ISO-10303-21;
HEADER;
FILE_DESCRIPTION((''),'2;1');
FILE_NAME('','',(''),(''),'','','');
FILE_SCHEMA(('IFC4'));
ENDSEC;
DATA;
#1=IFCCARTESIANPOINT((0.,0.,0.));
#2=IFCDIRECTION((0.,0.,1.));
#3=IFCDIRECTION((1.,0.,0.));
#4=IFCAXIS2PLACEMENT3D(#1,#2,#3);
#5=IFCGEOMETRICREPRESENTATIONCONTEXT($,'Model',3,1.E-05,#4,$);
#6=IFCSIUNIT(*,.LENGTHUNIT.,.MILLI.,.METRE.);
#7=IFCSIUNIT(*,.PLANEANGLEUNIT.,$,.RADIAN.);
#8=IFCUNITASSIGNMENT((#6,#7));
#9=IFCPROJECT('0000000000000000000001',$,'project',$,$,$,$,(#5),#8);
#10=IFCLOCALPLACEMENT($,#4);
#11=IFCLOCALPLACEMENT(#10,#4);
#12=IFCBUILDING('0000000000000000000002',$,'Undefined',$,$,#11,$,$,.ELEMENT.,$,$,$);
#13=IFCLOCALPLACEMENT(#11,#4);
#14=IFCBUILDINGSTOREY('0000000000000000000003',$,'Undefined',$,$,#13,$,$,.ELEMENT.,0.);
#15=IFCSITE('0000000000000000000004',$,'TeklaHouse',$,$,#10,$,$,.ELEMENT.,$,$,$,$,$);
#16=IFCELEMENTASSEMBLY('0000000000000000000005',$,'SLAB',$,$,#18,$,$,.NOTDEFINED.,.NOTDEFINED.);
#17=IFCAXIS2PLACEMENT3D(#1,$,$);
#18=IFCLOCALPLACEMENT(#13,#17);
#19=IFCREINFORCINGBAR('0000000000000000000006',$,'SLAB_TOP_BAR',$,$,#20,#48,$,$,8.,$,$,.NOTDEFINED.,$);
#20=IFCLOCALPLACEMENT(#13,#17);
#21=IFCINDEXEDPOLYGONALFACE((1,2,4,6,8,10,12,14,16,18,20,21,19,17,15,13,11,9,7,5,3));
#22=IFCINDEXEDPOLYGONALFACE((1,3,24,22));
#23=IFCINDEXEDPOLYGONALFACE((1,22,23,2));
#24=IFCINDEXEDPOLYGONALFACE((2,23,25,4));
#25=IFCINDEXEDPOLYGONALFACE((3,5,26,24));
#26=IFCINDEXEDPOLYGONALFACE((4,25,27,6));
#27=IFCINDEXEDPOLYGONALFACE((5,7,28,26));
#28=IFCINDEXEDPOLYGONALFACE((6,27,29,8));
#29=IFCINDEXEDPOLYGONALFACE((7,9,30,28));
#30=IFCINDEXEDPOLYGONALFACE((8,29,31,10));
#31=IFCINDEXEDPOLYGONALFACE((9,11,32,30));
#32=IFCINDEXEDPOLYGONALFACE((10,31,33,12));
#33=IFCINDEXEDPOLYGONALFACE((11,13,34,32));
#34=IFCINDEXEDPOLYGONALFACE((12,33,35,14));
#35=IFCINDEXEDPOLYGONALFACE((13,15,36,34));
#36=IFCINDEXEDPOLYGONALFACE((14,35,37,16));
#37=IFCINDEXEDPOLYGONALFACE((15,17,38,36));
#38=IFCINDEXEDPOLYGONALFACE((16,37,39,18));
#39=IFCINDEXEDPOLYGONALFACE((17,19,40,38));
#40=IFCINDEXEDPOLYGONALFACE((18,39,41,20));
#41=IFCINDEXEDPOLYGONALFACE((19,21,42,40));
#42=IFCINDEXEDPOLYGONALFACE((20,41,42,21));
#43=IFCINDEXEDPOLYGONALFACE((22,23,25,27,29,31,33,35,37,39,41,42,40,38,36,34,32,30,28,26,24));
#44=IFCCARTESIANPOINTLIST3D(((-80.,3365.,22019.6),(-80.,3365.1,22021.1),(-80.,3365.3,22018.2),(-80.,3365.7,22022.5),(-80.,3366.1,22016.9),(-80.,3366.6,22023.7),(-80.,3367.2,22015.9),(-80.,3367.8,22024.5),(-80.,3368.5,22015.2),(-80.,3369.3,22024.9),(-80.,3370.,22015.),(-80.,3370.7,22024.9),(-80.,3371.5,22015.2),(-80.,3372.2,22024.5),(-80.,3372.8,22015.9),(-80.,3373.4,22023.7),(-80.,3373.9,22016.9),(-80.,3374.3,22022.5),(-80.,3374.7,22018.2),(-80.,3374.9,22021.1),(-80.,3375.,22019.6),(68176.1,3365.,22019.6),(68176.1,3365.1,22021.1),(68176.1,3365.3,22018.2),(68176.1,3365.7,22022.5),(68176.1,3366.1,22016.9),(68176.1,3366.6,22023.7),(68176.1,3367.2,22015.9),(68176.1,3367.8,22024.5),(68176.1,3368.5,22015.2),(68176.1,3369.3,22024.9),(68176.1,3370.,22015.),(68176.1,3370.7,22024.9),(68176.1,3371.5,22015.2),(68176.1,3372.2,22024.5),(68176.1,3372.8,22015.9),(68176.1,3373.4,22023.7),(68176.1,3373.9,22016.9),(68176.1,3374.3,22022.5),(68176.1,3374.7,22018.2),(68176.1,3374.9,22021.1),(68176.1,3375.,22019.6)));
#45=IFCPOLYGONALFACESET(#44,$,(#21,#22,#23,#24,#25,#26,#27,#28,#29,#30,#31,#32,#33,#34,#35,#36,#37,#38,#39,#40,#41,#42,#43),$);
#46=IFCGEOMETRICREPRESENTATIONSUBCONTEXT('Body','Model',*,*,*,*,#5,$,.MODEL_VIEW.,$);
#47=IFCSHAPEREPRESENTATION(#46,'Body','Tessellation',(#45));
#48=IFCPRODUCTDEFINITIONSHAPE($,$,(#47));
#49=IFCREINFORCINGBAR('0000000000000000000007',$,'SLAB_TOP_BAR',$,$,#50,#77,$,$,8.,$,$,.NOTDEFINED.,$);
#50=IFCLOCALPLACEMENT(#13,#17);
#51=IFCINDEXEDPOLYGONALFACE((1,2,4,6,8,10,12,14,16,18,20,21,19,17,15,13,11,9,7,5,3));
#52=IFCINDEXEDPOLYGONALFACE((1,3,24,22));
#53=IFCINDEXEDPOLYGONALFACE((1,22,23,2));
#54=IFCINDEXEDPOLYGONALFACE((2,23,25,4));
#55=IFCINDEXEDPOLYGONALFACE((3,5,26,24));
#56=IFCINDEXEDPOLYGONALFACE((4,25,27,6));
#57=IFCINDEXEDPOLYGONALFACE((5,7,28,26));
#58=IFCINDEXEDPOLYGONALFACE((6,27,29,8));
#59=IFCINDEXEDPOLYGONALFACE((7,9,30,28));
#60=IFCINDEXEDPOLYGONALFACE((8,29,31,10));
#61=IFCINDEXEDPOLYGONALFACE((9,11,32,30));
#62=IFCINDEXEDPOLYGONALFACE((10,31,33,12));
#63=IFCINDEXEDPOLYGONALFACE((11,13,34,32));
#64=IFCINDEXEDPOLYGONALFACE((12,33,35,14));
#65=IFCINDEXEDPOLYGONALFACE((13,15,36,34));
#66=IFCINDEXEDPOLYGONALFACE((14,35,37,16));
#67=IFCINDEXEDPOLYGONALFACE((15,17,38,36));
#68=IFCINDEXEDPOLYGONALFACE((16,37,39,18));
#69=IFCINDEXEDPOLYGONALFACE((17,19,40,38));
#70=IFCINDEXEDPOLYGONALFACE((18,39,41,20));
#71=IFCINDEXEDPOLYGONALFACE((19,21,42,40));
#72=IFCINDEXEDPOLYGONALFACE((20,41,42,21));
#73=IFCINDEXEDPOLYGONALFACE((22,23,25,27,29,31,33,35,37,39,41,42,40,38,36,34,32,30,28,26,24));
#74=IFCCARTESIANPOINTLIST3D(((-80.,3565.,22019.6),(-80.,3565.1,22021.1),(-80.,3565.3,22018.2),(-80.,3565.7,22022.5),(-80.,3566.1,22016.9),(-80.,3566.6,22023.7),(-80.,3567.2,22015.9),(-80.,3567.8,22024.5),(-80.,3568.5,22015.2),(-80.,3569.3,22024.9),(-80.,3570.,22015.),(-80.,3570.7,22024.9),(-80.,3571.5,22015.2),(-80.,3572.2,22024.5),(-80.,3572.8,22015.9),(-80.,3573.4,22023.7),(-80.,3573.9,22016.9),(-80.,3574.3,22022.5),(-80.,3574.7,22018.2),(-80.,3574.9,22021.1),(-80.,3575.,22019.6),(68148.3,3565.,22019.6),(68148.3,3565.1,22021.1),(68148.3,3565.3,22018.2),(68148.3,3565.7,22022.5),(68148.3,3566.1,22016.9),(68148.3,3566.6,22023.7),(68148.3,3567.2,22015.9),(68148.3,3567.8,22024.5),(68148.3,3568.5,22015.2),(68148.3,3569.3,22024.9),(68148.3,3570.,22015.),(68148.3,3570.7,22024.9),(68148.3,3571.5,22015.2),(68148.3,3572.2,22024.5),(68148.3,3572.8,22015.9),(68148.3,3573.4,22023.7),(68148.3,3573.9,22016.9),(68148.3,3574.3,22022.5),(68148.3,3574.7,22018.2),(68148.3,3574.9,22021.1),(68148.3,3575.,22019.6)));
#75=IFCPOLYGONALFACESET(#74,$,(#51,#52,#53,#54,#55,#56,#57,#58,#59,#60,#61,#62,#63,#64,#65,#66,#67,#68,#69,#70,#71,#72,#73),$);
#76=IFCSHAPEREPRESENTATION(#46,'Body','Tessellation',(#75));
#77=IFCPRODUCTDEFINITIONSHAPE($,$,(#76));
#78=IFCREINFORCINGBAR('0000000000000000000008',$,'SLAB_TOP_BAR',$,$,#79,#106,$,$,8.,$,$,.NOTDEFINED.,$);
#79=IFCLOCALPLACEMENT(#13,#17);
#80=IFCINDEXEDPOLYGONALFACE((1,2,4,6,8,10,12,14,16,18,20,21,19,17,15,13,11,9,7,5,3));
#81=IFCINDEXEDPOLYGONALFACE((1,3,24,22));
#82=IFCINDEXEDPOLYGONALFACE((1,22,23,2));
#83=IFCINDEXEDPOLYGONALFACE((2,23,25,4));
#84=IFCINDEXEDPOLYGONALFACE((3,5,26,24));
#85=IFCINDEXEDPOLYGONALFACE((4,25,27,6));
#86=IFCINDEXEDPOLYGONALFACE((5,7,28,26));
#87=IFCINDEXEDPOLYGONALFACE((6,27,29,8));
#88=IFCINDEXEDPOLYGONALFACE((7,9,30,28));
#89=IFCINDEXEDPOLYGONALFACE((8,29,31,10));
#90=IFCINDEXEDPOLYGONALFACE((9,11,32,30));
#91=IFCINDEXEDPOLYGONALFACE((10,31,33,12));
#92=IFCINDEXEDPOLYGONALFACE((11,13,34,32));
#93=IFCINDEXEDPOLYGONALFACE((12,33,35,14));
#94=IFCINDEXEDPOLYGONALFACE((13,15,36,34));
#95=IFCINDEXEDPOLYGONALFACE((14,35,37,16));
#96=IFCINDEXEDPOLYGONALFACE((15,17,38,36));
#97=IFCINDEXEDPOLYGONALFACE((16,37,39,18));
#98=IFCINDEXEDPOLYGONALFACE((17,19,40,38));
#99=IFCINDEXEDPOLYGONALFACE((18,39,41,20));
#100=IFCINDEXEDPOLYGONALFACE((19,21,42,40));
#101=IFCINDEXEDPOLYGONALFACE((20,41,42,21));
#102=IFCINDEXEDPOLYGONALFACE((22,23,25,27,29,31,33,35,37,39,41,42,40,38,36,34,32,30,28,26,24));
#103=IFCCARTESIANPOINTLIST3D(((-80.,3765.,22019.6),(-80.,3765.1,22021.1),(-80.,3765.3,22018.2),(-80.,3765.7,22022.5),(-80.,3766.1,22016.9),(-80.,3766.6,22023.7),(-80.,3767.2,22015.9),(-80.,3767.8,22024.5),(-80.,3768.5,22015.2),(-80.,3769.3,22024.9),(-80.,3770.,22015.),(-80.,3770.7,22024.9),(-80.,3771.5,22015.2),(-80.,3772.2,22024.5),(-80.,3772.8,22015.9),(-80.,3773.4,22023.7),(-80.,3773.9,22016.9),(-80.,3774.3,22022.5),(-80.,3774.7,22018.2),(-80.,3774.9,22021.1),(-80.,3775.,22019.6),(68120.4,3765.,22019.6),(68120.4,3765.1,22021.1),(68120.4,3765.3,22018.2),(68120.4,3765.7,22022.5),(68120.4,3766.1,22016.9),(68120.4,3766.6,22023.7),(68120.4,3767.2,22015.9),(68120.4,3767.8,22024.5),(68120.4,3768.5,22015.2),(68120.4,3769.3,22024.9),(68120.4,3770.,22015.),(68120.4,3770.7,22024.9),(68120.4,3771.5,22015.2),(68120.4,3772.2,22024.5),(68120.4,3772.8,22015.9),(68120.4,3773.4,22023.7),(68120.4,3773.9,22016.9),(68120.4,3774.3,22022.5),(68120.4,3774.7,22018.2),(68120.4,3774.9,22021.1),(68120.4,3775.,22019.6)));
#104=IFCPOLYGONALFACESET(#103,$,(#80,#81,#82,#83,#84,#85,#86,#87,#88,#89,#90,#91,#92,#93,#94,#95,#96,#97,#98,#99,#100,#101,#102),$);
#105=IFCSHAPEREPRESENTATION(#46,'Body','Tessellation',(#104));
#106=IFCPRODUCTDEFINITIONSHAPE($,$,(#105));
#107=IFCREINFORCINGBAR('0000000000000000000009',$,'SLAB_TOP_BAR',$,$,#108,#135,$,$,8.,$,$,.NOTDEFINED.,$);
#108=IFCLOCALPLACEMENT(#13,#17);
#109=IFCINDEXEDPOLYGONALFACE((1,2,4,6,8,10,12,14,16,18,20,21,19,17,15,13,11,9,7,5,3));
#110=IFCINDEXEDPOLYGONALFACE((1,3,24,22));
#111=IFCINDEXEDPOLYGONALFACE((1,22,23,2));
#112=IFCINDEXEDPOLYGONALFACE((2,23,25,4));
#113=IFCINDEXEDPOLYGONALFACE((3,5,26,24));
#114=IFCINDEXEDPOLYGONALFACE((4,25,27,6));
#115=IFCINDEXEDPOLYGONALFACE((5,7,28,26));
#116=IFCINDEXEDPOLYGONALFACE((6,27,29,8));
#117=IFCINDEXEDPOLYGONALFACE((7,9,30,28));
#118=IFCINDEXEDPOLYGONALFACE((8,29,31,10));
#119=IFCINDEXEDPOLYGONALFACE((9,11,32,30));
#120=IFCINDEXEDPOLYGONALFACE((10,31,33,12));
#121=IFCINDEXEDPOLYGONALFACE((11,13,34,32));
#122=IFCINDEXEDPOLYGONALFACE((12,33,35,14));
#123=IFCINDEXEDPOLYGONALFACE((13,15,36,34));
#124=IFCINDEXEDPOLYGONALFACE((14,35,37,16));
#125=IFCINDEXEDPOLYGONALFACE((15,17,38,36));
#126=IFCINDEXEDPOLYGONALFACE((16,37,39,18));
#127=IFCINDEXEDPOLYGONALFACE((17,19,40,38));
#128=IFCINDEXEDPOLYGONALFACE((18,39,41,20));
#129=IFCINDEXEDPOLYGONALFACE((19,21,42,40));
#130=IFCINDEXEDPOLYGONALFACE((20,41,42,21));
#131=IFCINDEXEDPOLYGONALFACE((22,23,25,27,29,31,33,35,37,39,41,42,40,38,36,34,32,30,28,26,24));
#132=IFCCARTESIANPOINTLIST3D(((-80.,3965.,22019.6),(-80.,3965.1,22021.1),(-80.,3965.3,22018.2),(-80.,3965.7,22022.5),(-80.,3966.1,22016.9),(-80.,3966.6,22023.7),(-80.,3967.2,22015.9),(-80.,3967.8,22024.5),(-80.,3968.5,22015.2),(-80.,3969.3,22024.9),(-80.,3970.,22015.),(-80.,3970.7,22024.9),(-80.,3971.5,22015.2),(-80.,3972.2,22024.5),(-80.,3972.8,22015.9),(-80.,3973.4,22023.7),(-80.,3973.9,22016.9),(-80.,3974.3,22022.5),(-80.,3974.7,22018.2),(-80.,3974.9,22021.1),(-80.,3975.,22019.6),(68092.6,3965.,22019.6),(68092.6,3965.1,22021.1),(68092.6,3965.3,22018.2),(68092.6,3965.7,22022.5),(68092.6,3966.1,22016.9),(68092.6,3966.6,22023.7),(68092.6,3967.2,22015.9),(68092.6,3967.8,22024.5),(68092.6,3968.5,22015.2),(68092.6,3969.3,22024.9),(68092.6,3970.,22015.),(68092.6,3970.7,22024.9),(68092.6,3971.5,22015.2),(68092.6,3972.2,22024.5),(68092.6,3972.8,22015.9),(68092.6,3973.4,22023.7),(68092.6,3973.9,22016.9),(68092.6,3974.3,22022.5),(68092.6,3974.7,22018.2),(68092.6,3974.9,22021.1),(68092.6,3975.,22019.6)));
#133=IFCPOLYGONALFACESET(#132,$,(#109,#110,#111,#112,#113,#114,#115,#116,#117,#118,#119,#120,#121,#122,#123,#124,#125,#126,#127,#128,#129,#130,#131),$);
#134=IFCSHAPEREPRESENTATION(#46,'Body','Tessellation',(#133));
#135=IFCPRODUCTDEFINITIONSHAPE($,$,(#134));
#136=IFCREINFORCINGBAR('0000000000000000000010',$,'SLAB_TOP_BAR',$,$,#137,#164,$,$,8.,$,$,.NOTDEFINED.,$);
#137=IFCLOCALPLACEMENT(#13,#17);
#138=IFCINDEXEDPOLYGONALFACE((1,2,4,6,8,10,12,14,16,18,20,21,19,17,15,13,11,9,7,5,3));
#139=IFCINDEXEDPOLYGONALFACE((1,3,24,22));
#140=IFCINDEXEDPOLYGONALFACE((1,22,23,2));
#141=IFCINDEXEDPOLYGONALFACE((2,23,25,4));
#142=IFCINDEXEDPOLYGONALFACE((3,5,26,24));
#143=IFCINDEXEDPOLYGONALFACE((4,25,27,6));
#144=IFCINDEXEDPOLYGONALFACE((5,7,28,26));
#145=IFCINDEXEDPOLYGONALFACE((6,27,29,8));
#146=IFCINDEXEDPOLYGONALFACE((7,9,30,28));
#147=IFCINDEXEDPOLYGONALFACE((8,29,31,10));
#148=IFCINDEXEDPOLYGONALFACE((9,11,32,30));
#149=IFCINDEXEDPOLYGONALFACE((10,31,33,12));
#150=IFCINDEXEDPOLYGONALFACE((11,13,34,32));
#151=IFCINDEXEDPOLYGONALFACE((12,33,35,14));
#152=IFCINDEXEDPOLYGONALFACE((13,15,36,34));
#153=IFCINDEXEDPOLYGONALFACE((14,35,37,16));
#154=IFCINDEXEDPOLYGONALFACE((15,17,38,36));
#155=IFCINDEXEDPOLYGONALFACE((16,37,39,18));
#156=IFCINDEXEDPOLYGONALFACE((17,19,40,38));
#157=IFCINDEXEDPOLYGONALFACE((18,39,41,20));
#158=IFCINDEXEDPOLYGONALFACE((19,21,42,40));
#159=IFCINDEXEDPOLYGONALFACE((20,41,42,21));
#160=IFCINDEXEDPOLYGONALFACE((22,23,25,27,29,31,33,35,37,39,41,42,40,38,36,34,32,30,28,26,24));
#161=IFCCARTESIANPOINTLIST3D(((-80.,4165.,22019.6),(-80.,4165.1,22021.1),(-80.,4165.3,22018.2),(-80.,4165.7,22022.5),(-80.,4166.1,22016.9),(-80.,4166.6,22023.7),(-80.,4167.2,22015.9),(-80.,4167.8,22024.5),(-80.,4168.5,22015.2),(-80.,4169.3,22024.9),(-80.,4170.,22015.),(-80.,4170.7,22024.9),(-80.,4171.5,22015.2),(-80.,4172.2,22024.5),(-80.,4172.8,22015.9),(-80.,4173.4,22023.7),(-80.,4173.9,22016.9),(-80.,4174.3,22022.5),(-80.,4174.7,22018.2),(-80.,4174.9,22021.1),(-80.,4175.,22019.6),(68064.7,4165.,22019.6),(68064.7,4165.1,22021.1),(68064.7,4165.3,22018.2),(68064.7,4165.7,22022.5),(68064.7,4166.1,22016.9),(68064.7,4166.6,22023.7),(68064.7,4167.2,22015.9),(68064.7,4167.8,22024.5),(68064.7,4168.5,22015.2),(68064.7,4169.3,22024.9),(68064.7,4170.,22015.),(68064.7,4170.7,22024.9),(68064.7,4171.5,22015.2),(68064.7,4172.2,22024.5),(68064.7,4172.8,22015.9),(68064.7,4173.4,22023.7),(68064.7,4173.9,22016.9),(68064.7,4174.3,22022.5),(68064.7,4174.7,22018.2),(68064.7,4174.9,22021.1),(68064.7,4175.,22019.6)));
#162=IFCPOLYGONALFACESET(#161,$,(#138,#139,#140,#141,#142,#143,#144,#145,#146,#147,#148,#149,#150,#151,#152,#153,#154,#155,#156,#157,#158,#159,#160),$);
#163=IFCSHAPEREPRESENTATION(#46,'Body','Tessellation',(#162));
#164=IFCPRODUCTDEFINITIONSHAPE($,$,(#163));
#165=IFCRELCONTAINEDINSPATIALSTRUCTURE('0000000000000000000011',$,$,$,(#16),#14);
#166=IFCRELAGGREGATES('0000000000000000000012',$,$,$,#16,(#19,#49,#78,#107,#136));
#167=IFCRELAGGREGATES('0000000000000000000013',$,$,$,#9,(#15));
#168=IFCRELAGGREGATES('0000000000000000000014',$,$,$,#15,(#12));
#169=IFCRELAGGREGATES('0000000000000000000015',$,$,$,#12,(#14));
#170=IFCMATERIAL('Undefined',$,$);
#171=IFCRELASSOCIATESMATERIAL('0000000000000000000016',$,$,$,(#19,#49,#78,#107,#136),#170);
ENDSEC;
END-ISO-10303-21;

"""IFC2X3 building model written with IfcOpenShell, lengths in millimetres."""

from ifc_helpers import new_model, entity, si_unit, frame, origin_with_axes, place, context, subcontext, project, spatial, source, transform, mapped, material, element, aggregate, save


model = new_model("IFC2X3")

# Units and contexts
model_context = context("Model", 3, precision=1e-05, world=origin_with_axes())
body_context = subcontext(model_context, "Body", "Model", "MODEL_VIEW")
ifc_project = project(units=[si_unit("LENGTHUNIT", "METRE", prefix="MILLI"), si_unit("PLANEANGLEUNIT", "RADIAN")], contexts=[model_context])

# Site, building, storey
site_placement = place(None, origin_with_axes())
site = spatial("IfcSite", under=ifc_project, at=site_placement, Name="TeklaHouse", CompositionType="ELEMENT")
building_placement = place(site_placement, origin_with_axes())
building = spatial("IfcBuilding", under=site, at=building_placement, Name="Undefined", CompositionType="ELEMENT")
storey_placement = place(building_placement, origin_with_axes())
storey = spatial("IfcBuildingStorey", under=building, at=storey_placement, Name="Undefined", CompositionType="ELEMENT", Elevation=0.0)

# Shared definitions
ifc_material_1 = material(Name="Undefined")

# Element assembly, reinforcing bars
assembly_1_placement = place(storey_placement, origin_with_axes())
assembly_1 = element("IfcElementAssembly", 1, at=assembly_1_placement, inside=storey, Name="SLAB", AssemblyPlace="NOTDEFINED", PredefinedType="NOTDEFINED")
shared_shape_1 = source(origin_with_axes(), body_context, "Body", "AdvancedSweptSolid", [
    entity("IfcSweptDiskSolid", entity("IfcTrimmedCurve", entity("IfcLine", entity("IfcCartesianPoint", [0.0, 0.0, 0.0]), entity("IfcVector", entity("IfcDirection", [1.0, 0.0, 0.0]), 1.0)), [entity("IfcParameterValue", 0.0)], [entity("IfcParameterValue", 68256.122938)], True, "PARAMETER"), 5.0, None, 0.0, 68256.1),
])
reinforcing_bar_1_placement = place(assembly_1_placement, frame((68176.1, 3370.0, 22020.0), z_axis=(0.0, 0.0, -1.0), x_axis=(-1.0, 0.0, 0.0)))
reinforcing_bar_1 = element("IfcReinforcingBar", 2, at=reinforcing_bar_1_placement, material=ifc_material_1, Name="SLAB_TOP_BAR", BarRole="NOTDEFINED", NominalDiameter=8.0, context=body_context, shape_type="MappedRepresentation", body=[
    mapped(shared_shape_1, transform((0.0, 0.0, 0.0))),
])
shared_shape_2 = source(origin_with_axes(), body_context, "Body", "AdvancedSweptSolid", [
    entity("IfcSweptDiskSolid", entity("IfcTrimmedCurve", entity("IfcLine", entity("IfcCartesianPoint", [0.0, 0.0, 0.0]), entity("IfcVector", entity("IfcDirection", [1.0, 0.0, 0.0]), 1.0)), [entity("IfcParameterValue", 0.0)], [entity("IfcParameterValue", 68228.276481)], True, "PARAMETER"), 5.0, None, 0.0, 68228.3),
])
reinforcing_bar_2_placement = place(assembly_1_placement, frame((68148.3, 3570.0, 22020.0), z_axis=(0.0, 0.0, -1.0), x_axis=(-1.0, 0.0, 0.0)))
reinforcing_bar_2 = element("IfcReinforcingBar", 3, at=reinforcing_bar_2_placement, material=ifc_material_1, Name="SLAB_TOP_BAR", BarRole="NOTDEFINED", NominalDiameter=8.0, context=body_context, shape_type="MappedRepresentation", body=[
    mapped(shared_shape_2, transform((0.0, 0.0, 0.0))),
])
shared_shape_3 = source(origin_with_axes(), body_context, "Body", "AdvancedSweptSolid", [
    entity("IfcSweptDiskSolid", entity("IfcTrimmedCurve", entity("IfcLine", entity("IfcCartesianPoint", [0.0, 0.0, 0.0]), entity("IfcVector", entity("IfcDirection", [1.0, 0.0, 0.0]), 1.0)), [entity("IfcParameterValue", 0.0)], [entity("IfcParameterValue", 68200.430024)], True, "PARAMETER"), 5.0, None, 0.0, 68200.4),
])
reinforcing_bar_3_placement = place(assembly_1_placement, frame((68120.4, 3770.0, 22020.0), z_axis=(0.0, 0.0, -1.0), x_axis=(-1.0, 0.0, 0.0)))
reinforcing_bar_3 = element("IfcReinforcingBar", 4, at=reinforcing_bar_3_placement, material=ifc_material_1, Name="SLAB_TOP_BAR", BarRole="NOTDEFINED", NominalDiameter=8.0, context=body_context, shape_type="MappedRepresentation", body=[
    mapped(shared_shape_3, transform((0.0, 0.0, 0.0))),
])
shared_shape_4 = source(origin_with_axes(), body_context, "Body", "AdvancedSweptSolid", [
    entity("IfcSweptDiskSolid", entity("IfcTrimmedCurve", entity("IfcLine", entity("IfcCartesianPoint", [0.0, 0.0, 0.0]), entity("IfcVector", entity("IfcDirection", [1.0, 0.0, 0.0]), 1.0)), [entity("IfcParameterValue", 0.0)], [entity("IfcParameterValue", 68172.583566)], True, "PARAMETER"), 5.0, None, 0.0, 68172.6),
])
reinforcing_bar_4_placement = place(assembly_1_placement, frame((68092.6, 3970.0, 22020.0), z_axis=(0.0, 0.0, -1.0), x_axis=(-1.0, 0.0, 0.0)))
reinforcing_bar_4 = element("IfcReinforcingBar", 5, at=reinforcing_bar_4_placement, material=ifc_material_1, Name="SLAB_TOP_BAR", BarRole="NOTDEFINED", NominalDiameter=8.0, context=body_context, shape_type="MappedRepresentation", body=[
    mapped(shared_shape_4, transform((0.0, 0.0, 0.0))),
])
shared_shape_5 = source(origin_with_axes(), body_context, "Body", "AdvancedSweptSolid", [
    entity("IfcSweptDiskSolid", entity("IfcTrimmedCurve", entity("IfcLine", entity("IfcCartesianPoint", [0.0, 0.0, 0.0]), entity("IfcVector", entity("IfcDirection", [1.0, 0.0, 0.0]), 1.0)), [entity("IfcParameterValue", 0.0)], [entity("IfcParameterValue", 68144.737109)], True, "PARAMETER"), 5.0, None, 0.0, 68144.7),
])
reinforcing_bar_5_placement = place(assembly_1_placement, frame((68064.7, 4170.0, 22020.0), z_axis=(0.0, 0.0, -1.0), x_axis=(-1.0, 0.0, 0.0)))
reinforcing_bar_5 = element("IfcReinforcingBar", 6, at=reinforcing_bar_5_placement, material=ifc_material_1, Name="SLAB_TOP_BAR", BarRole="NOTDEFINED", NominalDiameter=8.0, context=body_context, shape_type="MappedRepresentation", body=[
    mapped(shared_shape_5, transform((0.0, 0.0, 0.0))),
])
aggregate(assembly_1, [reinforcing_bar_1, reinforcing_bar_2, reinforcing_bar_3, reinforcing_bar_4, reinforcing_bar_5])

save(model, "model.ifc")
